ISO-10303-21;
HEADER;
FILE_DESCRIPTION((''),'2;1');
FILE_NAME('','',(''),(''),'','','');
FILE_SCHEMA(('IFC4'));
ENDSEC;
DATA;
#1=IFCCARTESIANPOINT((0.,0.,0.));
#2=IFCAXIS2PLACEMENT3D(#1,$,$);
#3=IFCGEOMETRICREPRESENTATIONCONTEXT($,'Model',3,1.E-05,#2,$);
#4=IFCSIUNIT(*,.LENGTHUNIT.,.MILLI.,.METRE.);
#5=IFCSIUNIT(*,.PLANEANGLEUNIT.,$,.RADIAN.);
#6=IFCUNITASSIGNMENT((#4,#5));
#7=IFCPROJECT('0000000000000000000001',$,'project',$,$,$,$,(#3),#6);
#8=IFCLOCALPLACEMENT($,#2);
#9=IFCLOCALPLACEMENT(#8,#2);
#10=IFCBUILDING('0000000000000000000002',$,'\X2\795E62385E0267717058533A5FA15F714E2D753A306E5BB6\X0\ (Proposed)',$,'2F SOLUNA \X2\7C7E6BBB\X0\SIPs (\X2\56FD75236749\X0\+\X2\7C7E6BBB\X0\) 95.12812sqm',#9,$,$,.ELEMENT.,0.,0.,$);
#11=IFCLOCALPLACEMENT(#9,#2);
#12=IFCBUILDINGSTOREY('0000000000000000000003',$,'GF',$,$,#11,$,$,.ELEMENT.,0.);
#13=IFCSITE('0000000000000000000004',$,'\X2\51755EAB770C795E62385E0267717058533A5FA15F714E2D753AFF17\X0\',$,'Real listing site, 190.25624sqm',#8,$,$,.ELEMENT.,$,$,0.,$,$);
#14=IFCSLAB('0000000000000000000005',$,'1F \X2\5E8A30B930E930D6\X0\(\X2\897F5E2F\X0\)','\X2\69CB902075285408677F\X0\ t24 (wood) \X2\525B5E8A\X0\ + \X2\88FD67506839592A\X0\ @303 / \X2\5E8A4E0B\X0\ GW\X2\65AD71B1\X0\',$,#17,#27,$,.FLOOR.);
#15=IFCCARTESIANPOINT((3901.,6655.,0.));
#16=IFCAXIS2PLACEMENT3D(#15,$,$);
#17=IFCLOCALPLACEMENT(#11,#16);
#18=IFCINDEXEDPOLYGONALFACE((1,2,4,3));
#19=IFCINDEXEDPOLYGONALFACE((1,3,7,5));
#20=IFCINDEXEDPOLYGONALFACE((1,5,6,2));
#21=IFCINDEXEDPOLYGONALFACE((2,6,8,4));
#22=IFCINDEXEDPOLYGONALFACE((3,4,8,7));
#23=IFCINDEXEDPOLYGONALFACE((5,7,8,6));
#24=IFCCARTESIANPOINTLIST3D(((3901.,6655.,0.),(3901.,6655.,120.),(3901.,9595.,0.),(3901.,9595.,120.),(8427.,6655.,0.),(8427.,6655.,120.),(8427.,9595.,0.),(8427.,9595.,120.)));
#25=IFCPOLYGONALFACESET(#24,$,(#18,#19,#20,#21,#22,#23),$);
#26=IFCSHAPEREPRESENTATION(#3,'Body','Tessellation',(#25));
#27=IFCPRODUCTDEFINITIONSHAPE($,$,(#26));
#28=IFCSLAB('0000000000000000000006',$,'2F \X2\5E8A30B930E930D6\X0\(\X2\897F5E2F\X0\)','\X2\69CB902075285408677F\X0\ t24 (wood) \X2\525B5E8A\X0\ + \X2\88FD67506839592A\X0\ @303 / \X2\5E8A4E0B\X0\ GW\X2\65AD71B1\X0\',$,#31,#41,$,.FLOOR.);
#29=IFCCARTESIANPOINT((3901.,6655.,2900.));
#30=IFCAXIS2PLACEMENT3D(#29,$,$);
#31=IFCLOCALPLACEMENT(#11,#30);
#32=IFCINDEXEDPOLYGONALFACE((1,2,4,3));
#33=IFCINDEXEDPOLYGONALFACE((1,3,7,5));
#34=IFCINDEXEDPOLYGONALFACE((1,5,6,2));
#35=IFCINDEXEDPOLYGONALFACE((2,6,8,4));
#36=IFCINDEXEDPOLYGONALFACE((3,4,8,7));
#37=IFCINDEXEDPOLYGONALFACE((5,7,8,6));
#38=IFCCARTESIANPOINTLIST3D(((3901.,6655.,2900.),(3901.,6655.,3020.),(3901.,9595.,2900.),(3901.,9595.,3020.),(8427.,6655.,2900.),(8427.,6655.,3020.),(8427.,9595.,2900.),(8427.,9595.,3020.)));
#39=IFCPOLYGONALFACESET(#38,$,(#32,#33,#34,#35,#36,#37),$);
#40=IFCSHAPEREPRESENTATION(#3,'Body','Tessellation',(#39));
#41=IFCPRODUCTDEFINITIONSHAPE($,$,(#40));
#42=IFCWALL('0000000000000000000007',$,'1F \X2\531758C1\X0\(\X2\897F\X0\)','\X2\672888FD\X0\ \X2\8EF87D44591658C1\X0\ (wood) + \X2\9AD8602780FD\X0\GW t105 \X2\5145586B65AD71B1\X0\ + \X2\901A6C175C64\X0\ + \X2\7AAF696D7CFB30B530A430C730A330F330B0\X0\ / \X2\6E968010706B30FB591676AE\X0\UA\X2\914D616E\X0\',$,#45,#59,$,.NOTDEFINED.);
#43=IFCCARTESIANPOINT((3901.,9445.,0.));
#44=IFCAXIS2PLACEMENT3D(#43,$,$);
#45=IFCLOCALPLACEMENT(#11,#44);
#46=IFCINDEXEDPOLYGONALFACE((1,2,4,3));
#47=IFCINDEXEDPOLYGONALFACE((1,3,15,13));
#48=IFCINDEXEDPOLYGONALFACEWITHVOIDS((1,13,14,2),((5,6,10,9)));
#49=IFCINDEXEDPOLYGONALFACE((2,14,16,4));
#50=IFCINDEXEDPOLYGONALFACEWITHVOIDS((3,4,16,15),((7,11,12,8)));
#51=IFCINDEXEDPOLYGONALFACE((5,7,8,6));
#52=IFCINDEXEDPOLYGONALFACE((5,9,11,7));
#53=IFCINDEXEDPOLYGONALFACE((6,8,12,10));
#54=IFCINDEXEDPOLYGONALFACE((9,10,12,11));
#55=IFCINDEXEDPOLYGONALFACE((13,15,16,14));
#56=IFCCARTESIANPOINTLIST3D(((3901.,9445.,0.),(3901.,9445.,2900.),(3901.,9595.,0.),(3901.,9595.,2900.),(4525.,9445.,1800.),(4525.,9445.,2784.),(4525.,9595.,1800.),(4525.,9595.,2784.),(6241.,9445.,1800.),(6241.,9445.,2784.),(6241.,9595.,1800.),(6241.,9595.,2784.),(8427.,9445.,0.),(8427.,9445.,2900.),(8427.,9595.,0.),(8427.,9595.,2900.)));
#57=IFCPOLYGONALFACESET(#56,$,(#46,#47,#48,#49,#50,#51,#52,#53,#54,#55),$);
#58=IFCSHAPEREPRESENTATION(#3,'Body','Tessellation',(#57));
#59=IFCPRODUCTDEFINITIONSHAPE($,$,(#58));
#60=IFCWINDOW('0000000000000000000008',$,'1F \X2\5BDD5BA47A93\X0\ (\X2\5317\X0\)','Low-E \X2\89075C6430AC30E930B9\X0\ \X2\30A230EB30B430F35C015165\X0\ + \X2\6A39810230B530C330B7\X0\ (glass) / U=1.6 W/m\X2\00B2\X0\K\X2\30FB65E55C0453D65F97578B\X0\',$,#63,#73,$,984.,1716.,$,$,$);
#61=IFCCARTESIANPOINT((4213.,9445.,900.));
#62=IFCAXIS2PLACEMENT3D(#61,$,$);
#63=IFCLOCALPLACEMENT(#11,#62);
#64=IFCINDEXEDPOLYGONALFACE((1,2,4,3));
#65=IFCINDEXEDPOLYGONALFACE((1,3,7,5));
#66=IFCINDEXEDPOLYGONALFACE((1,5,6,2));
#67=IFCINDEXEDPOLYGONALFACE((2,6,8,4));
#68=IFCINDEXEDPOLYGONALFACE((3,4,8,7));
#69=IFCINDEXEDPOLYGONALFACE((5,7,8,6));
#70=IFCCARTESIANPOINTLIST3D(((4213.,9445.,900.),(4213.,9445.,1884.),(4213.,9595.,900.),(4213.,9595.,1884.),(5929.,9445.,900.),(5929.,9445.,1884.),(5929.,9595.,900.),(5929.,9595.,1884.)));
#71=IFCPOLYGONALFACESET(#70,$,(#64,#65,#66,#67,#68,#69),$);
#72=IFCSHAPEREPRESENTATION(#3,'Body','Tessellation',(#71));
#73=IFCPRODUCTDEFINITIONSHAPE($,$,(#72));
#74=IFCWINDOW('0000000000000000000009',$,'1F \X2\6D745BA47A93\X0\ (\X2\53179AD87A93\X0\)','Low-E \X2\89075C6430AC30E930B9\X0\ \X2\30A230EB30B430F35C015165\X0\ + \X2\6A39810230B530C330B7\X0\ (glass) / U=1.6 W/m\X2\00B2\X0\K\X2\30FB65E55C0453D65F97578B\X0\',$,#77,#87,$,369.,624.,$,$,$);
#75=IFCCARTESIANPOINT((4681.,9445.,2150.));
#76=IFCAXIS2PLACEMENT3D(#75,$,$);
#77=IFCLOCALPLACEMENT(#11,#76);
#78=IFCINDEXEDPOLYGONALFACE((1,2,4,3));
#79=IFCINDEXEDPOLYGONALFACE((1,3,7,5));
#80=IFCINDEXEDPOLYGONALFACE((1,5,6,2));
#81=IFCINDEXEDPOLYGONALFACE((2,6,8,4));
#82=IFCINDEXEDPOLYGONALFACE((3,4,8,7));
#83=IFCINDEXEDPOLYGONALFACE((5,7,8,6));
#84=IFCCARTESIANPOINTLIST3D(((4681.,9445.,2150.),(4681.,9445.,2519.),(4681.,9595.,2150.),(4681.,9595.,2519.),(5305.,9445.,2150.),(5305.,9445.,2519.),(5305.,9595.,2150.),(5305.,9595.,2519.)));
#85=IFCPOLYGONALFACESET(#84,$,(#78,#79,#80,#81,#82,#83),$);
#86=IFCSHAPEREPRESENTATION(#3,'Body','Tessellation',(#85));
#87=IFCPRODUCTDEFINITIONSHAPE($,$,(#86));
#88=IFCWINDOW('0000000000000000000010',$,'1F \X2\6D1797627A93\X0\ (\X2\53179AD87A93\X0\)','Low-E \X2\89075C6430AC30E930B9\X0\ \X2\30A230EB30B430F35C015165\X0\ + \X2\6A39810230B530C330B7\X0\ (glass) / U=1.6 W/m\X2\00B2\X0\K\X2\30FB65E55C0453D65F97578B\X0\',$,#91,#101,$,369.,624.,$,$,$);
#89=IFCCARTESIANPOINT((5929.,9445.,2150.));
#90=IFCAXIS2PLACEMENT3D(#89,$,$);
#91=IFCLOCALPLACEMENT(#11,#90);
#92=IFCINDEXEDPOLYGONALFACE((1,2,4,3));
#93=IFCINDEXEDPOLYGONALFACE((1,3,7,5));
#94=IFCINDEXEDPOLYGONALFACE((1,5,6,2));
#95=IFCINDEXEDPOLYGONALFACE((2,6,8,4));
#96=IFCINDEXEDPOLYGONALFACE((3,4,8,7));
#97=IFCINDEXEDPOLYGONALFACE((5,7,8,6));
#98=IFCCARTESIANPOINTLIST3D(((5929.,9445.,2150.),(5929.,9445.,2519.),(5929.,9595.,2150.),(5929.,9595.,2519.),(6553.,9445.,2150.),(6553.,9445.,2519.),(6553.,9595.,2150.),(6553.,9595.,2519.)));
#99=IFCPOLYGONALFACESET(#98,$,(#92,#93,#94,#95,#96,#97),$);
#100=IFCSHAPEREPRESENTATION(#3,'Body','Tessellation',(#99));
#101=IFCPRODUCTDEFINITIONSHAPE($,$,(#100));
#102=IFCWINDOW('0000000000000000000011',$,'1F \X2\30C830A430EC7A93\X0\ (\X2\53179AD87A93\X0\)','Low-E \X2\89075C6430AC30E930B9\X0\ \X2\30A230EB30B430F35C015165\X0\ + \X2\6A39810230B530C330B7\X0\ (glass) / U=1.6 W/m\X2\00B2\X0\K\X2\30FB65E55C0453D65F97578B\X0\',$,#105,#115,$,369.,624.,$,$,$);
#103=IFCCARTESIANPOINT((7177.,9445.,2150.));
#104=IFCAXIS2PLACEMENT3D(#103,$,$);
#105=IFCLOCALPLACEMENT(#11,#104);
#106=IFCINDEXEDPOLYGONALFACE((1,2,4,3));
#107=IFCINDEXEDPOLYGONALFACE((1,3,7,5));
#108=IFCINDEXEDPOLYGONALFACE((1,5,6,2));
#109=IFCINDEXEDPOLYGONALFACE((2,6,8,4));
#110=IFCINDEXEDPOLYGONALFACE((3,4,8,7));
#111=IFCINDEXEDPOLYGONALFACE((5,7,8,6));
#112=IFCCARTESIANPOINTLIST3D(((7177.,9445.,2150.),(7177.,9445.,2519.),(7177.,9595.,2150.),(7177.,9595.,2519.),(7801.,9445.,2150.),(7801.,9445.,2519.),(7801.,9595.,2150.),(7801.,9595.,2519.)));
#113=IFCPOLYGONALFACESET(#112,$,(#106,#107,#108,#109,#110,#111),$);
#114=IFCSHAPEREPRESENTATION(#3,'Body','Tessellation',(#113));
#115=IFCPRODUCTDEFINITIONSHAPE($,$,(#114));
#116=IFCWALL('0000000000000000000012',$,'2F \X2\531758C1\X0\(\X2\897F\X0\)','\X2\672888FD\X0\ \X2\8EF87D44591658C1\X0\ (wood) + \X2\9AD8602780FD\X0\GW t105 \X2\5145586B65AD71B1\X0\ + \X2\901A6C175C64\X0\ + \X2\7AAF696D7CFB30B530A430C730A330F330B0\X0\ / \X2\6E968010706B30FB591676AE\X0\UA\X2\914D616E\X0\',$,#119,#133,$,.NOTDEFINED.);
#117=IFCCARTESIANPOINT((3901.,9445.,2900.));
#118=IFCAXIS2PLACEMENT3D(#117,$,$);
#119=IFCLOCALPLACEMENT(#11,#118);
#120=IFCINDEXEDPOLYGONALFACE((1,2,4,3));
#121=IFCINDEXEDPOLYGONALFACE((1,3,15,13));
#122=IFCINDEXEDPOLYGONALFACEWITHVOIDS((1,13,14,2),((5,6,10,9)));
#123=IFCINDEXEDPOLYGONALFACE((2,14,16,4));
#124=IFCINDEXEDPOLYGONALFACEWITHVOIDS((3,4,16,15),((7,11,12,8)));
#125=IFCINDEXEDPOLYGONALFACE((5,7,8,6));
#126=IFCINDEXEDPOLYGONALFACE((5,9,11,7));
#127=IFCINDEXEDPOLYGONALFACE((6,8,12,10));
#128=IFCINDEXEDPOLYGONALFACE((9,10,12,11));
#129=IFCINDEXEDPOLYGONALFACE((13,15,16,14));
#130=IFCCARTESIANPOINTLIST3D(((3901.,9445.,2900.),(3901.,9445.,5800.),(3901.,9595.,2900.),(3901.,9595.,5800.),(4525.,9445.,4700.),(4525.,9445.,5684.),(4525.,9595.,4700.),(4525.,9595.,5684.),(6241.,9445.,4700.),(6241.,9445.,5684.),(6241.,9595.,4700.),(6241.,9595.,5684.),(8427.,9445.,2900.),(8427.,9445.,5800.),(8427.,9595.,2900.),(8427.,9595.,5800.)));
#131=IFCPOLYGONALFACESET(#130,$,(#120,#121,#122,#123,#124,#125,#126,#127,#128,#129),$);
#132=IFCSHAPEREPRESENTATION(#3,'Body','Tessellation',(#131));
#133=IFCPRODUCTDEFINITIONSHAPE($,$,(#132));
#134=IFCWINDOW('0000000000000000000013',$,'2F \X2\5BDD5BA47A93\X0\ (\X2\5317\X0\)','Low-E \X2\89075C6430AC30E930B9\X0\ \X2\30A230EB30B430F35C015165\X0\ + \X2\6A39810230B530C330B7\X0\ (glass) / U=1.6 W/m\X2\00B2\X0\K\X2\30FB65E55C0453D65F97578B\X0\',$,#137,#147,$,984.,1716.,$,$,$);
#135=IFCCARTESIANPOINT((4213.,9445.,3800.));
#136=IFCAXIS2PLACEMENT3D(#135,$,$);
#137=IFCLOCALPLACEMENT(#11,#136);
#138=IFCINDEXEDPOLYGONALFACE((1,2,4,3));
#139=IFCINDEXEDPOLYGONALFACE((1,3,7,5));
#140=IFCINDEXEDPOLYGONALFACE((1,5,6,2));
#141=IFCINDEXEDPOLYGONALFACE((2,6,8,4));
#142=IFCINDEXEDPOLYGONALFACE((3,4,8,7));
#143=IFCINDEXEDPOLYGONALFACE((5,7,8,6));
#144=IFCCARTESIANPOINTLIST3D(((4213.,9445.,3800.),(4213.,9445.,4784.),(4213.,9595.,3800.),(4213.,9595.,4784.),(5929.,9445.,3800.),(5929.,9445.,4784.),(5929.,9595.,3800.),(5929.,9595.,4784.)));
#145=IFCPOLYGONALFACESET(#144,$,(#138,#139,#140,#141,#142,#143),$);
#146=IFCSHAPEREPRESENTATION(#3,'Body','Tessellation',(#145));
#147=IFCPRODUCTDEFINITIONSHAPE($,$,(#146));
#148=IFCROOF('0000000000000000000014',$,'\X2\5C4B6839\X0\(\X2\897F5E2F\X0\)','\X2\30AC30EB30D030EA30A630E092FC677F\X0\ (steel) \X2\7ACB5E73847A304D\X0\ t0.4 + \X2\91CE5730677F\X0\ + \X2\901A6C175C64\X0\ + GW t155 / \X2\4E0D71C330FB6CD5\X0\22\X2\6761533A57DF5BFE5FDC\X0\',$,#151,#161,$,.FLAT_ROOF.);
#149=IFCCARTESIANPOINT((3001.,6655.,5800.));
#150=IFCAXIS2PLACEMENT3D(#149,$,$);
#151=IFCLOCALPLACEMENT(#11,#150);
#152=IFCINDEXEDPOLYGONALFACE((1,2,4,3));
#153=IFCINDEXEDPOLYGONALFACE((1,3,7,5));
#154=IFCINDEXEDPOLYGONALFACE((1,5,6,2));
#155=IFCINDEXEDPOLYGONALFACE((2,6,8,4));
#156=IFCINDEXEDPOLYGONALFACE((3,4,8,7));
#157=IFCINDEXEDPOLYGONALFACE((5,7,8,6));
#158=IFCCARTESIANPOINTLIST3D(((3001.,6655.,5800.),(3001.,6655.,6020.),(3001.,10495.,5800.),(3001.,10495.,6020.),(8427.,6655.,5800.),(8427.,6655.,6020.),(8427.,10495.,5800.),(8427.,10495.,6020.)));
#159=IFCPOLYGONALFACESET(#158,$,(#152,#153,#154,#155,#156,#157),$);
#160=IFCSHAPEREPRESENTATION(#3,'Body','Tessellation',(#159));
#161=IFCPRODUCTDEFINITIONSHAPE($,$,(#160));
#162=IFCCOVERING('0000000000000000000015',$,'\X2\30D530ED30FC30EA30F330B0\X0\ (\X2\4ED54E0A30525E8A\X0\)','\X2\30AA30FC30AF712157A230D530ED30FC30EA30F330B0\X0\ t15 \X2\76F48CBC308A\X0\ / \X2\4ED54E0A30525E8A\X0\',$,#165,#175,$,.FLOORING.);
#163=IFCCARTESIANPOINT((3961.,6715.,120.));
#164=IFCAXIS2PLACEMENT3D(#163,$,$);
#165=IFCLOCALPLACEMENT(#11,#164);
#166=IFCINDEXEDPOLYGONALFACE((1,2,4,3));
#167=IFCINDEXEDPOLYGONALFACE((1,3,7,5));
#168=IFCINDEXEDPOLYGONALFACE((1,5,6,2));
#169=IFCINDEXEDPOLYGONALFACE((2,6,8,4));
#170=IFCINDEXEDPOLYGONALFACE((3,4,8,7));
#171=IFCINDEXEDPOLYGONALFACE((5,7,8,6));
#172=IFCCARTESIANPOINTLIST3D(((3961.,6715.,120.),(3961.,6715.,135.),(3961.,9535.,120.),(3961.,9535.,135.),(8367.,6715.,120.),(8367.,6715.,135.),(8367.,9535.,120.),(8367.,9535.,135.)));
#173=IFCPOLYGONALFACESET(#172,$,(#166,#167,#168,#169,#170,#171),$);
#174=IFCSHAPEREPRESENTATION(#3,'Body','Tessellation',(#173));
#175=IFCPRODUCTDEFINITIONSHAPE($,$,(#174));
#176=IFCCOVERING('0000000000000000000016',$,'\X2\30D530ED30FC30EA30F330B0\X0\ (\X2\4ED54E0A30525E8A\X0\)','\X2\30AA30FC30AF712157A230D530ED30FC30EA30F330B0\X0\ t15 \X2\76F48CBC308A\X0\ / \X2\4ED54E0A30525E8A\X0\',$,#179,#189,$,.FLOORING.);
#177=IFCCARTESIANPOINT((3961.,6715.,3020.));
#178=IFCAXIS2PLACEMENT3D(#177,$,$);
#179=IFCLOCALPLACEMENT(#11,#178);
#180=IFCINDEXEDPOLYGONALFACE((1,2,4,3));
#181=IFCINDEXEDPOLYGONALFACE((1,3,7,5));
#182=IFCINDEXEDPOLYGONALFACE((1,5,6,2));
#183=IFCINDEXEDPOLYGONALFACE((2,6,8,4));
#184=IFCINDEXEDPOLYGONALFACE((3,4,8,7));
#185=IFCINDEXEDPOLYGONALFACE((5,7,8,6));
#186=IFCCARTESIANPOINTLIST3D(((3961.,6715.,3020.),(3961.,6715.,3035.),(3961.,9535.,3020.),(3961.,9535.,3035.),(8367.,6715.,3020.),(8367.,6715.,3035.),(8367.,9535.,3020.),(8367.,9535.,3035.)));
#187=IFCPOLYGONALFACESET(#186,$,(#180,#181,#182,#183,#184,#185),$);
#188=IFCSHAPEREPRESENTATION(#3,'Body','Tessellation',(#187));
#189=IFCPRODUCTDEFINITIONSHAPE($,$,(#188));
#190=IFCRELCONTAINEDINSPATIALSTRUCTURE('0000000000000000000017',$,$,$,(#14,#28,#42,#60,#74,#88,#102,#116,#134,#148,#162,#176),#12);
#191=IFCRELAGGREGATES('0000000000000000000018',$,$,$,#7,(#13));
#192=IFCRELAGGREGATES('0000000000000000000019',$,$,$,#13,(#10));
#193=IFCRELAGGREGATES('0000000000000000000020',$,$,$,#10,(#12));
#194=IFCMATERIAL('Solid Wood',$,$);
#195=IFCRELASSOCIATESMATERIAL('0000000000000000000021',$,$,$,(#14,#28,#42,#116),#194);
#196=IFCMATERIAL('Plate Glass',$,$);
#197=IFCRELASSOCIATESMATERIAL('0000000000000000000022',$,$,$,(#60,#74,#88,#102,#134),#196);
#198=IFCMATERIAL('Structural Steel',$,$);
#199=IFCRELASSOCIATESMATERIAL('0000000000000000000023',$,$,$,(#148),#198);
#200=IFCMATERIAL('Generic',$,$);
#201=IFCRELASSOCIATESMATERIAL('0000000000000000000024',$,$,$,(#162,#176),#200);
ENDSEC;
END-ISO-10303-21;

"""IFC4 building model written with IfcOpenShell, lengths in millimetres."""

from ifc_helpers import new_model, si_unit, frame, frame_2d, origin, place, context, project, spatial, rectangle, extrude, material, element, fill, save


model = new_model("IFC4")

# Units and contexts
model_context = context("Model", 3, precision=1e-05, world=origin())
ifc_project = project(units=[si_unit("LENGTHUNIT", "METRE", prefix="MILLI"), si_unit("PLANEANGLEUNIT", "RADIAN")], contexts=[model_context])

# Site, building, storey
site_placement = place(None, origin())
site = spatial("IfcSite", under=ifc_project, at=site_placement, Name="兵庫県神戸市東灘区御影中町７", ObjectType="Real listing site, 190.25624sqm", CompositionType="ELEMENT", RefElevation=0.0)
building_placement = place(site_placement, origin())
building = spatial("IfcBuilding", under=site, at=building_placement, Name="神戸市東灘区御影中町の家 (Proposed)", ObjectType="2F SOLUNA 籾殻SIPs (国産杉+籾殻) 95.12812sqm", CompositionType="ELEMENT", ElevationOfRefHeight=0.0, ElevationOfTerrain=0.0)
storey_placement = place(building_placement, origin())
storey = spatial("IfcBuildingStorey", under=building, at=storey_placement, Name="GF", CompositionType="ELEMENT", Elevation=0.0)

# Slabs
ifc_material_1 = material(Name="Solid Wood")
slab_1_placement = place(storey_placement, frame((3901.0, 6655.0, 0.0)))
element("IfcSlab", 1, at=slab_1_placement, inside=storey, material=ifc_material_1, Name="1F 床スラブ(西帯)", Description="構造用合板 t24 (wood) 剛床 + 製材根太 @303 / 床下 GW断熱", PredefinedType="FLOOR", context=model_context, shape_type="SweptSolid", body=[
    extrude(rectangle(XDim=4526.0, YDim=2940.0, at=frame_2d((2263.0, 1470.0))), frame((3901.0, 6655.0, 0.0)), (0.0, 0.0, 1.0), 120.0),
])
slab_2_placement = place(storey_placement, frame((3901.0, 6655.0, 2900.0)))
element("IfcSlab", 2, at=slab_2_placement, inside=storey, material=ifc_material_1, Name="2F 床スラブ(西帯)", Description="構造用合板 t24 (wood) 剛床 + 製材根太 @303 / 床下 GW断熱", PredefinedType="FLOOR", context=model_context, shape_type="SweptSolid", body=[
    extrude(rectangle(XDim=4526.0, YDim=2940.0, at=frame_2d((2263.0, 1470.0))), frame((3901.0, 6655.0, 2900.0)), (0.0, 0.0, 1.0), 120.0),
])

# Wall, openings, windows
wall_1_placement = place(storey_placement, frame((3901.0, 9445.0, 0.0)))
wall_1 = element("IfcWall", 3, at=wall_1_placement, inside=storey, material=ifc_material_1, Name="1F 北壁(西)", Description="木製 軸組外壁 (wood) + 高性能GW t105 充填断熱 + 通気層 + 窯業系サイディング / 準耐火・外皮UA配慮", PredefinedType="NOTDEFINED", context=model_context, shape_type="SweptSolid", body=[
    extrude(rectangle(XDim=4526.0, YDim=150.0, at=frame_2d((2263.0, 75.0))), frame((3901.0, 9445.0, 0.0)), (0.0, 0.0, 1.0), 2900.0),
])
opening_1_placement = place(storey_placement, frame((4213.0, 9445.0, 900.0)))
opening_1 = element("IfcOpeningElement", 4, at=opening_1_placement, cuts=wall_1, PredefinedType="NOTDEFINED", context=model_context, shape_type="SweptSolid", body=[
    extrude(rectangle(XDim=1716.0, YDim=150.0, at=frame_2d((858.0, 75.0))), frame((4213.0, 9445.0, 900.0)), (0.0, 0.0, 1.0), 984.0),
])
opening_2_placement = place(storey_placement, frame((4681.0, 9445.0, 2150.0)))
opening_2 = element("IfcOpeningElement", 5, at=opening_2_placement, cuts=wall_1, PredefinedType="NOTDEFINED", context=model_context, shape_type="SweptSolid", body=[
    extrude(rectangle(XDim=624.0, YDim=150.0, at=frame_2d((312.0, 75.0))), frame((4681.0, 9445.0, 2150.0)), (0.0, 0.0, 1.0), 369.0),
])
opening_3_placement = place(storey_placement, frame((5929.0, 9445.0, 2150.0)))
opening_3 = element("IfcOpeningElement", 6, at=opening_3_placement, cuts=wall_1, PredefinedType="NOTDEFINED", context=model_context, shape_type="SweptSolid", body=[
    extrude(rectangle(XDim=624.0, YDim=150.0, at=frame_2d((312.0, 75.0))), frame((5929.0, 9445.0, 2150.0)), (0.0, 0.0, 1.0), 369.0),
])
opening_4_placement = place(storey_placement, frame((7177.0, 9445.0, 2150.0)))
opening_4 = element("IfcOpeningElement", 7, at=opening_4_placement, cuts=wall_1, PredefinedType="NOTDEFINED", context=model_context, shape_type="SweptSolid", body=[
    extrude(rectangle(XDim=624.0, YDim=150.0, at=frame_2d((312.0, 75.0))), frame((7177.0, 9445.0, 2150.0)), (0.0, 0.0, 1.0), 369.0),
])
ifc_material_2 = material(Name="Plate Glass")
window_1_placement = place(storey_placement, frame((4213.0, 9445.0, 900.0)))
window_1 = element("IfcWindow", 8, at=window_1_placement, inside=storey, material=ifc_material_2, Name="1F 寝室窓 (北)", Description="Low-E 複層ガラス アルゴン封入 + 樹脂サッシ (glass) / U=1.6 W/m²K・日射取得型", OverallHeight=984.0, OverallWidth=1716.0, context=model_context, shape_type="SweptSolid", body=[
    extrude(rectangle(XDim=1716.0, YDim=150.0, at=frame_2d((858.0, 75.0))), frame((4213.0, 9445.0, 900.0)), (0.0, 0.0, 1.0), 984.0),
])
fill(opening_1, window_1)
window_2_placement = place(storey_placement, frame((4681.0, 9445.0, 2150.0)))
window_2 = element("IfcWindow", 9, at=window_2_placement, inside=storey, material=ifc_material_2, Name="1F 浴室窓 (北高窓)", Description="Low-E 複層ガラス アルゴン封入 + 樹脂サッシ (glass) / U=1.6 W/m²K・日射取得型", OverallHeight=369.0, OverallWidth=624.0, context=model_context, shape_type="SweptSolid", body=[
    extrude(rectangle(XDim=624.0, YDim=150.0, at=frame_2d((312.0, 75.0))), frame((4681.0, 9445.0, 2150.0)), (0.0, 0.0, 1.0), 369.0),
])
fill(opening_2, window_2)
window_3_placement = place(storey_placement, frame((5929.0, 9445.0, 2150.0)))
window_3 = element("IfcWindow", 10, at=window_3_placement, inside=storey, material=ifc_material_2, Name="1F 洗面窓 (北高窓)", Description="Low-E 複層ガラス アルゴン封入 + 樹脂サッシ (glass) / U=1.6 W/m²K・日射取得型", OverallHeight=369.0, OverallWidth=624.0, context=model_context, shape_type="SweptSolid", body=[
    extrude(rectangle(XDim=624.0, YDim=150.0, at=frame_2d((312.0, 75.0))), frame((5929.0, 9445.0, 2150.0)), (0.0, 0.0, 1.0), 369.0),
])
fill(opening_3, window_3)
window_4_placement = place(storey_placement, frame((7177.0, 9445.0, 2150.0)))
window_4 = element("IfcWindow", 11, at=window_4_placement, inside=storey, material=ifc_material_2, Name="1F トイレ窓 (北高窓)", Description="Low-E 複層ガラス アルゴン封入 + 樹脂サッシ (glass) / U=1.6 W/m²K・日射取得型", OverallHeight=369.0, OverallWidth=624.0, context=model_context, shape_type="SweptSolid", body=[
    extrude(rectangle(XDim=624.0, YDim=150.0, at=frame_2d((312.0, 75.0))), frame((7177.0, 9445.0, 2150.0)), (0.0, 0.0, 1.0), 369.0),
])
fill(opening_4, window_4)

# Wall, opening, window
wall_2_placement = place(storey_placement, frame((3901.0, 9445.0, 2900.0)))
wall_2 = element("IfcWall", 12, at=wall_2_placement, inside=storey, material=ifc_material_1, Name="2F 北壁(西)", Description="木製 軸組外壁 (wood) + 高性能GW t105 充填断熱 + 通気層 + 窯業系サイディング / 準耐火・外皮UA配慮", PredefinedType="NOTDEFINED", context=model_context, shape_type="SweptSolid", body=[
    extrude(rectangle(XDim=4526.0, YDim=150.0, at=frame_2d((2263.0, 75.0))), frame((3901.0, 9445.0, 2900.0)), (0.0, 0.0, 1.0), 2900.0),
])
opening_5_placement = place(storey_placement, frame((4213.0, 9445.0, 3800.0)))
opening_5 = element("IfcOpeningElement", 13, at=opening_5_placement, cuts=wall_2, PredefinedType="NOTDEFINED", context=model_context, shape_type="SweptSolid", body=[
    extrude(rectangle(XDim=1716.0, YDim=150.0, at=frame_2d((858.0, 75.0))), frame((4213.0, 9445.0, 3800.0)), (0.0, 0.0, 1.0), 984.0),
])
window_5_placement = place(storey_placement, frame((4213.0, 9445.0, 3800.0)))
window_5 = element("IfcWindow", 14, at=window_5_placement, inside=storey, material=ifc_material_2, Name="2F 寝室窓 (北)", Description="Low-E 複層ガラス アルゴン封入 + 樹脂サッシ (glass) / U=1.6 W/m²K・日射取得型", OverallHeight=984.0, OverallWidth=1716.0, context=model_context, shape_type="SweptSolid", body=[
    extrude(rectangle(XDim=1716.0, YDim=150.0, at=frame_2d((858.0, 75.0))), frame((4213.0, 9445.0, 3800.0)), (0.0, 0.0, 1.0), 984.0),
])
fill(opening_5, window_5)

# Roof
ifc_material_3 = material(Name="Structural Steel")
for number, where, name in (
    (15, (3001.0, 6655.0, 5800.0), "屋根(西帯)"),
):
    element("IfcRoof", number, at=place(storey_placement, frame(where)), inside=storey, material=ifc_material_3, Name=name, Description="ガルバリウム鋼板 (steel) 立平葺き t0.4 + 野地板 + 通気層 + GW t155 / 不燃・法22条区域対応", PredefinedType="FLAT_ROOF", context=model_context, shape_type="SweptSolid", body=[
        extrude(rectangle(XDim=5426.0, YDim=3840.0, at=frame_2d((2713.0, 1920.0))), frame((3001.0, 6655.0, 5800.0)), (0.0, 0.0, 1.0), 220.0),
    ])

# Coverings
ifc_material_4 = material(Name="Generic")
covering_1_placement = place(storey_placement, frame((3961.0, 6715.0, 120.0)))
element("IfcCovering", 16, at=covering_1_placement, inside=storey, material=ifc_material_4, Name="フローリング (仕上げ床)", Description="オーク無垢フローリング t15 直貼り / 仕上げ床", PredefinedType="FLOORING", context=model_context, shape_type="SweptSolid", body=[
    extrude(rectangle(XDim=4406.0, YDim=2820.0, at=frame_2d((2203.0, 1410.0))), frame((3961.0, 6715.0, 120.0)), (0.0, 0.0, 1.0), 15.0),
])
covering_2_placement = place(storey_placement, frame((3961.0, 6715.0, 3020.0)))
element("IfcCovering", 17, at=covering_2_placement, inside=storey, material=ifc_material_4, Name="フローリング (仕上げ床)", Description="オーク無垢フローリング t15 直貼り / 仕上げ床", PredefinedType="FLOORING", context=model_context, shape_type="SweptSolid", body=[
    extrude(rectangle(XDim=4406.0, YDim=2820.0, at=frame_2d((2203.0, 1410.0))), frame((3961.0, 6715.0, 3020.0)), (0.0, 0.0, 1.0), 15.0),
])

save(model, "model.ifc")
